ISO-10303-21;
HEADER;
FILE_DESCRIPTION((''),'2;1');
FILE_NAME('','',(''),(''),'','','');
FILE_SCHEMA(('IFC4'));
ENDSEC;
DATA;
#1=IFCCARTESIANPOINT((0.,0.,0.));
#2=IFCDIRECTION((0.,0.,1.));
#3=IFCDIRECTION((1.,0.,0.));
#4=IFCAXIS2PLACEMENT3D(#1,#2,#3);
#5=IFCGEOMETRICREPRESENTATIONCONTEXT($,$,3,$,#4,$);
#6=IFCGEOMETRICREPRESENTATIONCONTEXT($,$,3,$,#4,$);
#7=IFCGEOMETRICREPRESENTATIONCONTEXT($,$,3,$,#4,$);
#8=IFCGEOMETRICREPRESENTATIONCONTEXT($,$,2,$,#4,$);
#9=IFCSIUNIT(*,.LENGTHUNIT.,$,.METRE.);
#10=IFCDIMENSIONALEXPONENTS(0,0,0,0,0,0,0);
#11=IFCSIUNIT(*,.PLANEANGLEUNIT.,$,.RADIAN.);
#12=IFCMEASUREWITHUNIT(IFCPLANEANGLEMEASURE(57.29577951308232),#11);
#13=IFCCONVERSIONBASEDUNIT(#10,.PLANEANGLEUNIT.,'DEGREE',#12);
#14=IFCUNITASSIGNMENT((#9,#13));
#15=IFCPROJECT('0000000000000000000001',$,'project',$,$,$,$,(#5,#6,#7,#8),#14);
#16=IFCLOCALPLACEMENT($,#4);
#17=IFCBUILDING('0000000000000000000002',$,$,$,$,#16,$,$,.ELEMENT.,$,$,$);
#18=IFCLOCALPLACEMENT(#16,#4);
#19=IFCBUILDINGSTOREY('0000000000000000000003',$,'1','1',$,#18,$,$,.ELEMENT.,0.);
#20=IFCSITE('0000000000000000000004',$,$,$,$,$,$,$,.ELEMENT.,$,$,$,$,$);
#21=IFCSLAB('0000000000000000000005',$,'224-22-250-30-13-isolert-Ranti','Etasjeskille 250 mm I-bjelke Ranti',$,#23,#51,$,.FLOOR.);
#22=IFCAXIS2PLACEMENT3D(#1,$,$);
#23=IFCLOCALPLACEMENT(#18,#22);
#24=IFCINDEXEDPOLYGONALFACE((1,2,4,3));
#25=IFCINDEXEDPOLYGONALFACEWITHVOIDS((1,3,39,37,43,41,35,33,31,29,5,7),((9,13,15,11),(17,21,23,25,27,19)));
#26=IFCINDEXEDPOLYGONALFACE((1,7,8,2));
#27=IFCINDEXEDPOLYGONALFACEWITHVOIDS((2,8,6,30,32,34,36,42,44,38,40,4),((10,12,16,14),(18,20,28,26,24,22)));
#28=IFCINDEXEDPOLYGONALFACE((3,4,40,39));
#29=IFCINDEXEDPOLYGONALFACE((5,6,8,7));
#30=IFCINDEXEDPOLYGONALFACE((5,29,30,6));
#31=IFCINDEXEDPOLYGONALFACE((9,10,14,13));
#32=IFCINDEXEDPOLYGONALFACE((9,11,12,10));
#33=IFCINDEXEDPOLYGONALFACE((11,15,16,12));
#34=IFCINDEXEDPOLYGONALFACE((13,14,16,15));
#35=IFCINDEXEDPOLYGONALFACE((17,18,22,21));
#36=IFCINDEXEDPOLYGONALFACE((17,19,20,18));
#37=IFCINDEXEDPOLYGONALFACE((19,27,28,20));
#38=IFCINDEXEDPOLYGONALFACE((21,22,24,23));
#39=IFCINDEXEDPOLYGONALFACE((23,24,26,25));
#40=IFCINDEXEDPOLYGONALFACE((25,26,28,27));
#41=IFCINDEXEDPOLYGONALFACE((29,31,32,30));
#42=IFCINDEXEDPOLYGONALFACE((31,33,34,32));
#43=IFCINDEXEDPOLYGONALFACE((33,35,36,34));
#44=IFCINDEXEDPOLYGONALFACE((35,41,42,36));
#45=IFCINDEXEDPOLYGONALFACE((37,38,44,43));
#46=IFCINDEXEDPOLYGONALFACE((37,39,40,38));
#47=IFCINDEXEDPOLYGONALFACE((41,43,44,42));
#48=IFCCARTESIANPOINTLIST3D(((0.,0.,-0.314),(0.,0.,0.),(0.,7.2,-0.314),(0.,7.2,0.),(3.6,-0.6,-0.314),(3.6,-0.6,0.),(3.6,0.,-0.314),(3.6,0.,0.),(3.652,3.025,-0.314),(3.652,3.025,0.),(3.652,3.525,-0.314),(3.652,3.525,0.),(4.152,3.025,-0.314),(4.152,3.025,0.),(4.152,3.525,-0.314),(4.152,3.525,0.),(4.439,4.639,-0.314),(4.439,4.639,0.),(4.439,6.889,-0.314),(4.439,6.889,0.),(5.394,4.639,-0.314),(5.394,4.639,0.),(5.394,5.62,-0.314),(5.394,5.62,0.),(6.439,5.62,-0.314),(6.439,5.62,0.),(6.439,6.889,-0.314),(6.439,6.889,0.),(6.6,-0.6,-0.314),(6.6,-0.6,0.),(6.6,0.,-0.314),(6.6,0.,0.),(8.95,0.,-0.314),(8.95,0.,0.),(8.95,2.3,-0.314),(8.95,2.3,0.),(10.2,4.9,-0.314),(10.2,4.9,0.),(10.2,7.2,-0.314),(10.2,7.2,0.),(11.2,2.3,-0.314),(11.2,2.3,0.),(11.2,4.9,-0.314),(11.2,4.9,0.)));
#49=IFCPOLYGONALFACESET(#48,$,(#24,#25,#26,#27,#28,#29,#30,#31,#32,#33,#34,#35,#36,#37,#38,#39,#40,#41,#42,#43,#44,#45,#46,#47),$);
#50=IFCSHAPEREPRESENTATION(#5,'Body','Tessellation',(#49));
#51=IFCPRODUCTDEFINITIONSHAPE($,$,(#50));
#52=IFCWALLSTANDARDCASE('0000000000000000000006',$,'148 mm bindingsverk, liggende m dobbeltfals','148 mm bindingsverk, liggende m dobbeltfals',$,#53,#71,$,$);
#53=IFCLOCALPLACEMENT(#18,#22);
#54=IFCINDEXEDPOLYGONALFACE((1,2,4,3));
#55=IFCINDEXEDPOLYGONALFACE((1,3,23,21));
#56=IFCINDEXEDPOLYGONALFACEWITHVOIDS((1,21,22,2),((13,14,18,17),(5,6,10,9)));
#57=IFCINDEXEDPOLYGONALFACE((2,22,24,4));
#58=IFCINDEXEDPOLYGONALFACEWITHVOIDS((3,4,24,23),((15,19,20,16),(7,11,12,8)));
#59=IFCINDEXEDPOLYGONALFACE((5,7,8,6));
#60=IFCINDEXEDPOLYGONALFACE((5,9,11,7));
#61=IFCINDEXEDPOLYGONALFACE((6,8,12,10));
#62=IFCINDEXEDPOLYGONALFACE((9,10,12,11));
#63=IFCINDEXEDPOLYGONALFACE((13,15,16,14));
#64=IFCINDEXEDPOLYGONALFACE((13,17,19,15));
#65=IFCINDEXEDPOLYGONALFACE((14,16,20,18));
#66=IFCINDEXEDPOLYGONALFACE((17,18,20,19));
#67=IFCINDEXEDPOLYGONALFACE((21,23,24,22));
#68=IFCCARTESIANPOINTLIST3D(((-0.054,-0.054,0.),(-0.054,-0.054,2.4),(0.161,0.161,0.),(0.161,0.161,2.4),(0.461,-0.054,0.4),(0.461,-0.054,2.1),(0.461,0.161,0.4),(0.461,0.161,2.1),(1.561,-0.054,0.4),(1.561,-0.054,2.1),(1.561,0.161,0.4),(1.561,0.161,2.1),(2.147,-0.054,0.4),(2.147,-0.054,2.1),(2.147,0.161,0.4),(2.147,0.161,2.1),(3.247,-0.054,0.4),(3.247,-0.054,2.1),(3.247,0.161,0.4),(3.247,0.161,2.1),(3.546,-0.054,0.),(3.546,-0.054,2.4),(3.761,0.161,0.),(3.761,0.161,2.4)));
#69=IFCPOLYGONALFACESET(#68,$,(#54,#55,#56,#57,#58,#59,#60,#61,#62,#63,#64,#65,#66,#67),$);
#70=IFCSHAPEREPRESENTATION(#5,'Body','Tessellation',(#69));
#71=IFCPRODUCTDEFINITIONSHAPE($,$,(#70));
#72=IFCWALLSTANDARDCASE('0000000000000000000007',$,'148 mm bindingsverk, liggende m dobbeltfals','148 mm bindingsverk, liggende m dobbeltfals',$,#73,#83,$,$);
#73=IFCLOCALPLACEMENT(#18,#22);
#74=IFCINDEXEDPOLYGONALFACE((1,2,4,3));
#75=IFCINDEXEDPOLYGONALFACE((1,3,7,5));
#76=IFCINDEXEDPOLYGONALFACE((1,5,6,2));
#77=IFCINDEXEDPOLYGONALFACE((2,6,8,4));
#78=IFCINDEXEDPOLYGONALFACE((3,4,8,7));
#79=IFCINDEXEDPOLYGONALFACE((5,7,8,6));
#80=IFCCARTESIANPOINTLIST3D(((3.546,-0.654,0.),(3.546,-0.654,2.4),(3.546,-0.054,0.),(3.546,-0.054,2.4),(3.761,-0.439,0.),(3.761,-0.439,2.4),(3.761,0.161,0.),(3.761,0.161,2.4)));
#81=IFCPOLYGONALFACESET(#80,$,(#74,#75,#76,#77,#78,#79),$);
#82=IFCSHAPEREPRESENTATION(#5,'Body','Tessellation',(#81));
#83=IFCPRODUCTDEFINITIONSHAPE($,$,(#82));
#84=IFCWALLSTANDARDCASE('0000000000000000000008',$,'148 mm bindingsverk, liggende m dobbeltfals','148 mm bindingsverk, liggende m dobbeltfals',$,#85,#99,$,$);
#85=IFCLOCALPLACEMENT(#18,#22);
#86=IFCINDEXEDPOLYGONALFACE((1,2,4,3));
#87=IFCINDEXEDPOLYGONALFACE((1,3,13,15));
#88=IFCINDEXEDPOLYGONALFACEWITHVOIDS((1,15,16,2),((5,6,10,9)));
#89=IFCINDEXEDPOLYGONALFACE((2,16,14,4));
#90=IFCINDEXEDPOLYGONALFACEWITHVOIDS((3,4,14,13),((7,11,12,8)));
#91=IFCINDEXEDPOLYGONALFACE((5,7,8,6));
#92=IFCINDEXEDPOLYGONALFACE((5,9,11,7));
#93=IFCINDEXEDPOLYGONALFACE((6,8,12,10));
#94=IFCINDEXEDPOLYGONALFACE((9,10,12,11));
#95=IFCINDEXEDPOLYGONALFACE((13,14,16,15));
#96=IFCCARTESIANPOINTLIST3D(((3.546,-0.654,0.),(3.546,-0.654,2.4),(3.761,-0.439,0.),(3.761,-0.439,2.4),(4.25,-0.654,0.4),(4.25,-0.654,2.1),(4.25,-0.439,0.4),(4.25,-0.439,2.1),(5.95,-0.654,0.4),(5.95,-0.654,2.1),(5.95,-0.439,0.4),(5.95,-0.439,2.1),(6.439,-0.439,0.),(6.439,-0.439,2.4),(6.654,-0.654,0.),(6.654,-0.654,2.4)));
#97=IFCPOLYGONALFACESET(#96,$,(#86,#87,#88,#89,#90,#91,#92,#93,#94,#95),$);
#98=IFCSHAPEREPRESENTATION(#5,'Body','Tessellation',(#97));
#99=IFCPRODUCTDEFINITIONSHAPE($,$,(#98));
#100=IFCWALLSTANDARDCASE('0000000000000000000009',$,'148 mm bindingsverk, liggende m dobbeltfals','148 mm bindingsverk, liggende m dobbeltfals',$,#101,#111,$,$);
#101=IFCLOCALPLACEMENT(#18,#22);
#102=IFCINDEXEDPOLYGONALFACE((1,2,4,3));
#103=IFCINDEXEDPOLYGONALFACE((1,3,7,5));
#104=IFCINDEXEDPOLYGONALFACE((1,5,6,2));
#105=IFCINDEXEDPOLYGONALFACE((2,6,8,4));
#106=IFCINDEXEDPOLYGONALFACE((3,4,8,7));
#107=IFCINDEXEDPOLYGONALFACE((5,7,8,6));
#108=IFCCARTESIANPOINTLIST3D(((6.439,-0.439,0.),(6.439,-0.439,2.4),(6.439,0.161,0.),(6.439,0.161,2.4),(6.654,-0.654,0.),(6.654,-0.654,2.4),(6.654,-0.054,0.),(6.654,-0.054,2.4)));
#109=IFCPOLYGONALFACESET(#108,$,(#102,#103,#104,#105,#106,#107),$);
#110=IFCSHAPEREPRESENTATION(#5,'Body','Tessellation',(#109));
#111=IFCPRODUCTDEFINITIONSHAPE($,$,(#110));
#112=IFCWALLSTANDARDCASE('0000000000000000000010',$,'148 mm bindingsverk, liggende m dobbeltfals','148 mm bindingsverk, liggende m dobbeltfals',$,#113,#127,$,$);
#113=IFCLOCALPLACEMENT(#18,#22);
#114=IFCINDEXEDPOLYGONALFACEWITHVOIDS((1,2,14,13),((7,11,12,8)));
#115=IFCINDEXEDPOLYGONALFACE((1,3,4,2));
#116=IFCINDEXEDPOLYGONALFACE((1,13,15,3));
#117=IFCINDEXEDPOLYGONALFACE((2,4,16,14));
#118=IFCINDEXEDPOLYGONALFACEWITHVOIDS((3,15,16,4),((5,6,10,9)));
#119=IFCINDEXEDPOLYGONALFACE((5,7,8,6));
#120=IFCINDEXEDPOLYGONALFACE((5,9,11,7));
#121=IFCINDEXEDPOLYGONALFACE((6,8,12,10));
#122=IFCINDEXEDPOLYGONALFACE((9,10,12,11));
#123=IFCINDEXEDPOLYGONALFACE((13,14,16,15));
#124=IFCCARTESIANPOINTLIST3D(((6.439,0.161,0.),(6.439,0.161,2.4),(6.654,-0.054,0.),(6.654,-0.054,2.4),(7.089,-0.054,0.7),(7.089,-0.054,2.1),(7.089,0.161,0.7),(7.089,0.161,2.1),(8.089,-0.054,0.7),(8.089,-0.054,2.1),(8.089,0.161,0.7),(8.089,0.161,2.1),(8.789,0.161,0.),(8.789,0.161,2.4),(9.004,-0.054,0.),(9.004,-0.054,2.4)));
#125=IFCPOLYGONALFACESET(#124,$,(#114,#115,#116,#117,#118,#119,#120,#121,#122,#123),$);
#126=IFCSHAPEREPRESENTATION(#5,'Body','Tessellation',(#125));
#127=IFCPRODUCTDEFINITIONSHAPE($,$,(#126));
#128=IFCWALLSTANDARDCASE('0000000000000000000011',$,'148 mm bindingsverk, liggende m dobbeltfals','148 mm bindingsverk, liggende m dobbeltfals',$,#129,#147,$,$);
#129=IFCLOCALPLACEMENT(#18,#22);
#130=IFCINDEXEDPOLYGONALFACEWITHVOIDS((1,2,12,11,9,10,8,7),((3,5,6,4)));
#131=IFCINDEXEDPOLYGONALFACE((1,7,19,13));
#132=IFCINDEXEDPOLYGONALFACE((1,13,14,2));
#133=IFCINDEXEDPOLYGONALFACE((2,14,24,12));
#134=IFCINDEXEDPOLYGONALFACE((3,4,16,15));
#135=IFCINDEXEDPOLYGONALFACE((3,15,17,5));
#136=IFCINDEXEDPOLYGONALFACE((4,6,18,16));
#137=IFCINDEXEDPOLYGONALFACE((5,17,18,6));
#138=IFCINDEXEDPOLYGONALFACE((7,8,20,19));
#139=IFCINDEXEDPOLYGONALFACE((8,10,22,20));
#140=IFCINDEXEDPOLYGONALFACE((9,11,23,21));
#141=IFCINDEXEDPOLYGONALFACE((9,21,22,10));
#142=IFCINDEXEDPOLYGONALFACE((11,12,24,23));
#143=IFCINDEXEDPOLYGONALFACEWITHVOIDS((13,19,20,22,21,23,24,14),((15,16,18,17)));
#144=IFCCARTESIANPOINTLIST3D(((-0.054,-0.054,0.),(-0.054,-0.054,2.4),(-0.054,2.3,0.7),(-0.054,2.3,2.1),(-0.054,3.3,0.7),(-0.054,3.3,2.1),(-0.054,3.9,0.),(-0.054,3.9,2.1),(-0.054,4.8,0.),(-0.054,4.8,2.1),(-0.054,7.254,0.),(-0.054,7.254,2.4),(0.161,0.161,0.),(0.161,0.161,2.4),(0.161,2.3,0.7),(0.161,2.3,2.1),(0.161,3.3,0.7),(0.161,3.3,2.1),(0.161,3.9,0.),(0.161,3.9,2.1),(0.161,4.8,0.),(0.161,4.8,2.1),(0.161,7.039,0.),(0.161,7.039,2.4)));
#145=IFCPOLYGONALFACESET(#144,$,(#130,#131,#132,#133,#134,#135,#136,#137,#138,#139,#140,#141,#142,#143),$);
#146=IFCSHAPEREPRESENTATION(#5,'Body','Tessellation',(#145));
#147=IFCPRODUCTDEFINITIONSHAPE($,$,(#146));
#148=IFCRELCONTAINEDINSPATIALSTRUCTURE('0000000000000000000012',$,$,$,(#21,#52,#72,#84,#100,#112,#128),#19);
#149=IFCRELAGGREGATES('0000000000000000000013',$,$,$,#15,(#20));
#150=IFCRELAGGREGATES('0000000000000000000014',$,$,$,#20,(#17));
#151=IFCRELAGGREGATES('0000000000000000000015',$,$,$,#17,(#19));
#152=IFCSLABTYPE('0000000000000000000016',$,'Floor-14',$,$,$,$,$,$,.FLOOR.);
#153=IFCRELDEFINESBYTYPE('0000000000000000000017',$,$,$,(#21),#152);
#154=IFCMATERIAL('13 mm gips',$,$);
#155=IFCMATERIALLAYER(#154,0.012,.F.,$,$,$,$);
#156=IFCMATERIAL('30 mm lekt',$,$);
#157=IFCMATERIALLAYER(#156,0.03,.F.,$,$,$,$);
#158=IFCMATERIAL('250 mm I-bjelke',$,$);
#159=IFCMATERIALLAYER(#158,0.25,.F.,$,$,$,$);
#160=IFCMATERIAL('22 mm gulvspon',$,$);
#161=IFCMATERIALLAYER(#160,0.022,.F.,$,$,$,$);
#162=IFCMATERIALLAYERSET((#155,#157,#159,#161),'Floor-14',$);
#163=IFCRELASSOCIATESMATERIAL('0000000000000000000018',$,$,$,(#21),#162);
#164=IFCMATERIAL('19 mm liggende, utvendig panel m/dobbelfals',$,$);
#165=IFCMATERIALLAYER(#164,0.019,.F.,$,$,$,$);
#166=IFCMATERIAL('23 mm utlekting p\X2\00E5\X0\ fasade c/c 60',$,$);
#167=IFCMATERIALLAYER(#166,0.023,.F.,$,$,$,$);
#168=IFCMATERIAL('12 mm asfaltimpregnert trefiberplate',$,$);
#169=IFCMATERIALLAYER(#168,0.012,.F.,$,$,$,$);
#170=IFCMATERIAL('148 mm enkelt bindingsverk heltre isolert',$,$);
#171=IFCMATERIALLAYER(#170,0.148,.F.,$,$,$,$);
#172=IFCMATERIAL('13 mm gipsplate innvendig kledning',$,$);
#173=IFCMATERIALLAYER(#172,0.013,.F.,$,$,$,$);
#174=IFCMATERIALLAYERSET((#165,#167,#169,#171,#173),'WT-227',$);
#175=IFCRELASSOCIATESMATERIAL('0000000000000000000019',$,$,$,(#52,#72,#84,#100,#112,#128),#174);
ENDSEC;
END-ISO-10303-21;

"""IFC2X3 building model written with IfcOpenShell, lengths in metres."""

from ifc_helpers import new_model, entity, si_unit, converted_unit, frame, origin_with_axes, place, context, project, spatial, polyline, outline, extrude, material, layer, layer_set, layer_usage, type_object, element, save


model = new_model("IFC2X3")

# Units and contexts
context_of_model_1 = context(None, 3, world=origin_with_axes())
context_of_model_2 = context(None, 3, world=origin_with_axes())
context_of_model_3 = context(None, 3, world=origin_with_axes())
context_of_model_4 = context(None, 2, world=origin_with_axes())
ifc_project = project(units=[si_unit("LENGTHUNIT", "METRE"), converted_unit("PLANEANGLEUNIT", "DEGREE", entity("IfcPlaneAngleMeasure", 57.29577951308232), si_unit("PLANEANGLEUNIT", "RADIAN"), dimensions=[0, 0, 0, 0, 0, 0, 0])], contexts=[context_of_model_1, context_of_model_2, context_of_model_3, context_of_model_4])

# Site, building, storey
site = spatial("IfcSite", under=ifc_project, CompositionType="ELEMENT")
building_placement = place(None, origin_with_axes())
building = spatial("IfcBuilding", under=site, at=building_placement, CompositionType="ELEMENT")
storey_placement = place(building_placement, origin_with_axes())
storey = spatial("IfcBuildingStorey", under=building, at=storey_placement, Name="1", Description="1", CompositionType="ELEMENT", Elevation=0.0)

# Slab, openings
ifc_material_1 = material(Name="13 mm gips")
ifc_layer_1 = layer(ifc_material_1, 0.012, ventilated=False)
ifc_material_2 = material(Name="30 mm lekt")
ifc_layer_2 = layer(ifc_material_2, 0.03, ventilated=False)
ifc_material_3 = material(Name="250 mm I-bjelke")
ifc_layer_3 = layer(ifc_material_3, 0.25, ventilated=False)
ifc_material_4 = material(Name="22 mm gulvspon")
ifc_layer_4 = layer(ifc_material_4, 0.022, ventilated=False)
ifc_layer_set_1 = layer_set([ifc_layer_1, ifc_layer_2, ifc_layer_3, ifc_layer_4], Name="Floor-14")
ifc_layer_usage_1 = layer_usage(ifc_layer_set_1, "AXIS3", "NEGATIVE", 0.0)
slab_type = type_object("IfcSlabType", Name="Floor-14", PredefinedType="FLOOR")
slab_placement = place(storey_placement, frame((0.0, 0.0, -0.314), z_axis=(0.0, 0.0, 1.0), x_axis=(1.0, 0.0, 0.0)))
slab = element("IfcSlab", 1, at=slab_placement, inside=storey, type_object=slab_type, material=ifc_layer_usage_1, Name="224-22-250-30-13-isolert-Ranti", Description="Etasjeskille 250 mm I-bjelke Ranti", PredefinedType="FLOOR", context=context_of_model_1, shape_type="SweptSolid", body=[
    extrude(outline(polyline([(0.0, 0.0), (3.6, 0.0), (3.6, 0.6), (6.6, 0.6), (6.6, 0.0), (8.95, 0.0), (8.95, -2.3), (11.2, -2.3), (11.2, -4.9), (10.2, -4.9), (10.2, -7.2), (0.0, -7.2), (0.0, 0.0)])), frame((0.0, 0.0, 0.0), z_axis=(0.0, 0.0, -1.0), x_axis=(1.0, 0.0, 0.0)), (0.0, 0.0, -1.0), 0.314),
])
opening_1_placement = place(slab_placement, frame((3.652, 3.025, 0.0), z_axis=(0.0, 0.0, 1.0), x_axis=(1.0, 0.0, 0.0)))
element("IfcOpeningElement", 2, at=opening_1_placement, inside=storey, cuts=slab, context=context_of_model_1, shape_type="SweptSolid", body=[
    extrude(outline(polyline([(0.0, 0.0), (0.5, 0.0), (0.5, 0.5), (0.0, 0.5), (0.0, 0.0)])), origin_with_axes(), (0.0, 0.0, 1.0), 0.314),
])
opening_2_placement = place(slab_placement, frame((4.439, 4.639, 0.0), z_axis=(0.0, 0.0, 1.0), x_axis=(1.0, 0.0, 0.0)))
element("IfcOpeningElement", 3, at=opening_2_placement, inside=storey, cuts=slab, context=context_of_model_1, shape_type="SweptSolid", body=[
    extrude(outline(polyline([(0.0, 0.0), (0.955, 0.0), (0.955, 0.981), (2.0, 0.981), (2.0, 2.25), (0.0, 2.25), (0.0, 0.0)])), origin_with_axes(), (0.0, 0.0, 1.0), 0.314),
])

# Wall, openings
ifc_material_5 = material(Name="19 mm liggende, utvendig panel m/dobbelfals")
ifc_layer_5 = layer(ifc_material_5, 0.019, ventilated=False)
ifc_material_6 = material(Name="23 mm utlekting på fasade c/c 60")
ifc_layer_6 = layer(ifc_material_6, 0.023, ventilated=False)
ifc_material_7 = material(Name="12 mm asfaltimpregnert trefiberplate")
ifc_layer_7 = layer(ifc_material_7, 0.012, ventilated=False)
ifc_material_8 = material(Name="148 mm enkelt bindingsverk heltre isolert")
ifc_layer_8 = layer(ifc_material_8, 0.148, ventilated=False)
ifc_material_9 = material(Name="13 mm gipsplate innvendig kledning")
ifc_layer_9 = layer(ifc_material_9, 0.013, ventilated=False)
ifc_layer_set_2 = layer_set([ifc_layer_5, ifc_layer_6, ifc_layer_7, ifc_layer_8, ifc_layer_9], Name="WT-227")
ifc_layer_usage_2 = layer_usage(ifc_layer_set_2, "AXIS2", "POSITIVE", 0.0)
wall_1_placement = place(storey_placement, frame((-0.054, -0.054, 0.0), z_axis=(0.0, 0.0, 1.0), x_axis=(1.0, 0.0, 0.0)))
wall_1 = element("IfcWallStandardCase", 4, at=wall_1_placement, inside=storey, material=ifc_layer_usage_2, Name="148 mm bindingsverk, liggende m dobbeltfals", Description="148 mm bindingsverk, liggende m dobbeltfals", context=context_of_model_1, shape_type="SweptSolid", body=[
    extrude(outline(polyline([(0.0, 0.0), (3.6, 0.0), (3.815, 0.215), (0.215, 0.215), (0.0, 0.0)])), frame((0.0, 0.0, 0.0), z_axis=(0.0, 0.0, 1.0), x_axis=(1.0, 0.000001, 0.0)), (0.0, 0.0, 1.0), 2.4),
])
opening_3_placement = place(wall_1_placement, frame((0.515, 0.0, 0.4), z_axis=(0.0, 0.0, 1.0), x_axis=(1.0, 0.0, 0.0)))
element("IfcOpeningElement", 5, at=opening_3_placement, inside=storey, cuts=wall_1, context=context_of_model_1, shape_type="SweptSolid", body=[
    extrude(outline(polyline([(0.0, 0.0), (1.7, 0.0), (1.7, 1.1), (0.0, 1.1), (0.0, 0.0)])), frame((0.0, 0.0, 0.0), z_axis=(-0.000001, 1.0, 0.0), x_axis=(0.0, 0.0, 1.0)), (0.0, 0.000001, 1.0), 0.215),
])
opening_4_placement = place(wall_1_placement, frame((2.201, 0.0, 0.4), z_axis=(0.0, 0.0, 1.0), x_axis=(1.0, 0.0, 0.0)))
element("IfcOpeningElement", 6, at=opening_4_placement, inside=storey, cuts=wall_1, context=context_of_model_1, shape_type="SweptSolid", body=[
    extrude(outline(polyline([(0.0, 0.0), (1.7, 0.0), (1.7, 1.1), (0.0, 1.1), (0.0, 0.0)])), frame((0.0, 0.0, 0.0), z_axis=(-0.000001, 1.0, 0.0), x_axis=(0.0, 0.0, 1.0)), (0.0, 0.000001, 1.0), 0.215),
])

# Wall
wall_2_placement = place(storey_placement, frame((3.546, -0.054, 0.0), z_axis=(0.0, 0.0, 1.0), x_axis=(0.0, -1.0, 0.0)))
element("IfcWallStandardCase", 7, at=wall_2_placement, inside=storey, material=ifc_layer_usage_2, Name="148 mm bindingsverk, liggende m dobbeltfals", Description="148 mm bindingsverk, liggende m dobbeltfals", context=context_of_model_1, shape_type="SweptSolid", body=[
    extrude(outline(polyline([(0.0, 0.0), (0.6, 0.0), (0.385, 0.215), (-0.215, 0.215), (0.0, 0.0)])), frame((0.0, 0.0, 0.0), z_axis=(0.0, 0.0, 1.0), x_axis=(1.0, 0.000002, 0.0)), (0.0, 0.0, 1.0), 2.4),
])

# Wall, opening
wall_3_placement = place(storey_placement, frame((3.546, -0.654, 0.0), z_axis=(0.0, 0.0, 1.0), x_axis=(1.0, 0.0, 0.0)))
wall_3 = element("IfcWallStandardCase", 8, at=wall_3_placement, inside=storey, material=ifc_layer_usage_2, Name="148 mm bindingsverk, liggende m dobbeltfals", Description="148 mm bindingsverk, liggende m dobbeltfals", context=context_of_model_1, shape_type="SweptSolid", body=[
    extrude(outline(polyline([(0.0, 0.0), (3.108, 0.0), (2.893, 0.215), (0.215, 0.215), (0.0, 0.0)])), frame((0.0, 0.0, 0.0), z_axis=(0.0, 0.0, 1.0), x_axis=(1.0, 0.000001, 0.0)), (0.0, 0.0, 1.0), 2.4),
])
opening_5_placement = place(wall_3_placement, frame((0.704, 0.0, 0.4), z_axis=(0.0, 0.0, 1.0), x_axis=(1.0, 0.0, 0.0)))
element("IfcOpeningElement", 9, at=opening_5_placement, inside=storey, cuts=wall_3, context=context_of_model_1, shape_type="SweptSolid", body=[
    extrude(outline(polyline([(0.0, 0.0), (1.7, 0.0), (1.7, 1.7), (0.0, 1.7), (0.0, 0.0)])), frame((0.0, 0.0, 0.0), z_axis=(-0.000001, 1.0, 0.0), x_axis=(0.0, 0.0, 1.0)), (0.0, 0.000001, 1.0), 0.215),
])

# Wall
wall_4_placement = place(storey_placement, frame((6.654, -0.654, 0.0), z_axis=(0.0, 0.0, 1.0), x_axis=(0.0, 1.0, 0.0)))
element("IfcWallStandardCase", 10, at=wall_4_placement, inside=storey, material=ifc_layer_usage_2, Name="148 mm bindingsverk, liggende m dobbeltfals", Description="148 mm bindingsverk, liggende m dobbeltfals", context=context_of_model_1, shape_type="SweptSolid", body=[
    extrude(outline(polyline([(0.0, 0.0), (0.6, 0.0), (0.815, 0.215), (0.215, 0.215), (0.0, 0.0)])), frame((0.0, 0.0, 0.0), z_axis=(0.0, 0.0, 1.0), x_axis=(1.0, 0.0, 0.0)), (0.0, 0.0, 1.0), 2.4),
])

# Wall, opening
wall_5_placement = place(storey_placement, frame((6.654, -0.054, 0.0), z_axis=(0.0, 0.0, 1.0), x_axis=(1.0, 0.0, 0.0)))
wall_5 = element("IfcWallStandardCase", 11, at=wall_5_placement, inside=storey, material=ifc_layer_usage_2, Name="148 mm bindingsverk, liggende m dobbeltfals", Description="148 mm bindingsverk, liggende m dobbeltfals", context=context_of_model_1, shape_type="SweptSolid", body=[
    extrude(outline(polyline([(0.0, 0.0), (2.35, 0.0), (2.135, 0.215), (-0.215, 0.215), (0.0, 0.0)])), frame((0.0, 0.0, 0.0), z_axis=(0.0, 0.0, 1.0), x_axis=(1.0, 0.000001, 0.0)), (0.0, 0.0, 1.0), 2.4),
])
opening_6_placement = place(wall_5_placement, frame((0.435, 0.0, 0.7), z_axis=(0.0, 0.0, 1.0), x_axis=(1.0, 0.0, 0.0)))
element("IfcOpeningElement", 12, at=opening_6_placement, inside=storey, cuts=wall_5, context=context_of_model_1, shape_type="SweptSolid", body=[
    extrude(outline(polyline([(0.0, 0.0), (1.4, 0.0), (1.4, 1.0), (0.0, 1.0), (0.0, 0.0)])), frame((0.0, 0.0, 0.0), z_axis=(-0.000001, 1.0, 0.0), x_axis=(0.0, 0.0, 1.0)), (0.0, 0.000001, 1.0), 0.215),
])

# Wall, openings
wall_6_placement = place(storey_placement, frame((-0.054, 7.254, 0.0), z_axis=(0.0, 0.0, 1.0), x_axis=(0.0, -1.0, 0.0)))
wall_6 = element("IfcWallStandardCase", 13, at=wall_6_placement, inside=storey, material=ifc_layer_usage_2, Name="148 mm bindingsverk, liggende m dobbeltfals", Description="148 mm bindingsverk, liggende m dobbeltfals", context=context_of_model_1, shape_type="SweptSolid", body=[
    extrude(outline(polyline([(0.0, 0.0), (7.308, 0.0), (7.093, 0.215), (0.215, 0.215), (0.0, 0.0)])), frame((0.0, 0.0, 0.0), z_axis=(0.0, 0.0, 1.0), x_axis=(1.0, 0.0, 0.0)), (0.0, 0.0, 1.0), 2.4),
])
opening_7_placement = place(wall_6_placement, frame((2.454, 0.0, 0.0), z_axis=(0.0, 0.0, 1.0), x_axis=(1.0, 0.0, 0.0)))
element("IfcOpeningElement", 14, at=opening_7_placement, inside=storey, cuts=wall_6, context=context_of_model_1, shape_type="SweptSolid", body=[
    extrude(outline(polyline([(0.0, 0.0), (2.1, 0.0), (2.1, 0.9), (0.0, 0.9), (0.0, 0.0)])), frame((0.0, 0.0, 0.0), z_axis=(0.0, 1.0, 0.0), x_axis=(0.0, 0.0, 1.0)), (0.0, 0.0, 1.0), 0.215),
])
opening_8_placement = place(wall_6_placement, frame((3.954, 0.0, 0.7), z_axis=(0.0, 0.0, 1.0), x_axis=(1.0, 0.0, 0.0)))
element("IfcOpeningElement", 15, at=opening_8_placement, inside=storey, cuts=wall_6, context=context_of_model_1, shape_type="SweptSolid", body=[
    extrude(outline(polyline([(0.0, 0.0), (1.4, 0.0), (1.4, 1.0), (0.0, 1.0), (0.0, 0.0)])), frame((0.0, 0.0, 0.0), z_axis=(0.0, 1.0, 0.0), x_axis=(0.0, 0.0, 1.0)), (0.0, 0.0, 1.0), 0.215),
])

save(model, "model.ifc")
